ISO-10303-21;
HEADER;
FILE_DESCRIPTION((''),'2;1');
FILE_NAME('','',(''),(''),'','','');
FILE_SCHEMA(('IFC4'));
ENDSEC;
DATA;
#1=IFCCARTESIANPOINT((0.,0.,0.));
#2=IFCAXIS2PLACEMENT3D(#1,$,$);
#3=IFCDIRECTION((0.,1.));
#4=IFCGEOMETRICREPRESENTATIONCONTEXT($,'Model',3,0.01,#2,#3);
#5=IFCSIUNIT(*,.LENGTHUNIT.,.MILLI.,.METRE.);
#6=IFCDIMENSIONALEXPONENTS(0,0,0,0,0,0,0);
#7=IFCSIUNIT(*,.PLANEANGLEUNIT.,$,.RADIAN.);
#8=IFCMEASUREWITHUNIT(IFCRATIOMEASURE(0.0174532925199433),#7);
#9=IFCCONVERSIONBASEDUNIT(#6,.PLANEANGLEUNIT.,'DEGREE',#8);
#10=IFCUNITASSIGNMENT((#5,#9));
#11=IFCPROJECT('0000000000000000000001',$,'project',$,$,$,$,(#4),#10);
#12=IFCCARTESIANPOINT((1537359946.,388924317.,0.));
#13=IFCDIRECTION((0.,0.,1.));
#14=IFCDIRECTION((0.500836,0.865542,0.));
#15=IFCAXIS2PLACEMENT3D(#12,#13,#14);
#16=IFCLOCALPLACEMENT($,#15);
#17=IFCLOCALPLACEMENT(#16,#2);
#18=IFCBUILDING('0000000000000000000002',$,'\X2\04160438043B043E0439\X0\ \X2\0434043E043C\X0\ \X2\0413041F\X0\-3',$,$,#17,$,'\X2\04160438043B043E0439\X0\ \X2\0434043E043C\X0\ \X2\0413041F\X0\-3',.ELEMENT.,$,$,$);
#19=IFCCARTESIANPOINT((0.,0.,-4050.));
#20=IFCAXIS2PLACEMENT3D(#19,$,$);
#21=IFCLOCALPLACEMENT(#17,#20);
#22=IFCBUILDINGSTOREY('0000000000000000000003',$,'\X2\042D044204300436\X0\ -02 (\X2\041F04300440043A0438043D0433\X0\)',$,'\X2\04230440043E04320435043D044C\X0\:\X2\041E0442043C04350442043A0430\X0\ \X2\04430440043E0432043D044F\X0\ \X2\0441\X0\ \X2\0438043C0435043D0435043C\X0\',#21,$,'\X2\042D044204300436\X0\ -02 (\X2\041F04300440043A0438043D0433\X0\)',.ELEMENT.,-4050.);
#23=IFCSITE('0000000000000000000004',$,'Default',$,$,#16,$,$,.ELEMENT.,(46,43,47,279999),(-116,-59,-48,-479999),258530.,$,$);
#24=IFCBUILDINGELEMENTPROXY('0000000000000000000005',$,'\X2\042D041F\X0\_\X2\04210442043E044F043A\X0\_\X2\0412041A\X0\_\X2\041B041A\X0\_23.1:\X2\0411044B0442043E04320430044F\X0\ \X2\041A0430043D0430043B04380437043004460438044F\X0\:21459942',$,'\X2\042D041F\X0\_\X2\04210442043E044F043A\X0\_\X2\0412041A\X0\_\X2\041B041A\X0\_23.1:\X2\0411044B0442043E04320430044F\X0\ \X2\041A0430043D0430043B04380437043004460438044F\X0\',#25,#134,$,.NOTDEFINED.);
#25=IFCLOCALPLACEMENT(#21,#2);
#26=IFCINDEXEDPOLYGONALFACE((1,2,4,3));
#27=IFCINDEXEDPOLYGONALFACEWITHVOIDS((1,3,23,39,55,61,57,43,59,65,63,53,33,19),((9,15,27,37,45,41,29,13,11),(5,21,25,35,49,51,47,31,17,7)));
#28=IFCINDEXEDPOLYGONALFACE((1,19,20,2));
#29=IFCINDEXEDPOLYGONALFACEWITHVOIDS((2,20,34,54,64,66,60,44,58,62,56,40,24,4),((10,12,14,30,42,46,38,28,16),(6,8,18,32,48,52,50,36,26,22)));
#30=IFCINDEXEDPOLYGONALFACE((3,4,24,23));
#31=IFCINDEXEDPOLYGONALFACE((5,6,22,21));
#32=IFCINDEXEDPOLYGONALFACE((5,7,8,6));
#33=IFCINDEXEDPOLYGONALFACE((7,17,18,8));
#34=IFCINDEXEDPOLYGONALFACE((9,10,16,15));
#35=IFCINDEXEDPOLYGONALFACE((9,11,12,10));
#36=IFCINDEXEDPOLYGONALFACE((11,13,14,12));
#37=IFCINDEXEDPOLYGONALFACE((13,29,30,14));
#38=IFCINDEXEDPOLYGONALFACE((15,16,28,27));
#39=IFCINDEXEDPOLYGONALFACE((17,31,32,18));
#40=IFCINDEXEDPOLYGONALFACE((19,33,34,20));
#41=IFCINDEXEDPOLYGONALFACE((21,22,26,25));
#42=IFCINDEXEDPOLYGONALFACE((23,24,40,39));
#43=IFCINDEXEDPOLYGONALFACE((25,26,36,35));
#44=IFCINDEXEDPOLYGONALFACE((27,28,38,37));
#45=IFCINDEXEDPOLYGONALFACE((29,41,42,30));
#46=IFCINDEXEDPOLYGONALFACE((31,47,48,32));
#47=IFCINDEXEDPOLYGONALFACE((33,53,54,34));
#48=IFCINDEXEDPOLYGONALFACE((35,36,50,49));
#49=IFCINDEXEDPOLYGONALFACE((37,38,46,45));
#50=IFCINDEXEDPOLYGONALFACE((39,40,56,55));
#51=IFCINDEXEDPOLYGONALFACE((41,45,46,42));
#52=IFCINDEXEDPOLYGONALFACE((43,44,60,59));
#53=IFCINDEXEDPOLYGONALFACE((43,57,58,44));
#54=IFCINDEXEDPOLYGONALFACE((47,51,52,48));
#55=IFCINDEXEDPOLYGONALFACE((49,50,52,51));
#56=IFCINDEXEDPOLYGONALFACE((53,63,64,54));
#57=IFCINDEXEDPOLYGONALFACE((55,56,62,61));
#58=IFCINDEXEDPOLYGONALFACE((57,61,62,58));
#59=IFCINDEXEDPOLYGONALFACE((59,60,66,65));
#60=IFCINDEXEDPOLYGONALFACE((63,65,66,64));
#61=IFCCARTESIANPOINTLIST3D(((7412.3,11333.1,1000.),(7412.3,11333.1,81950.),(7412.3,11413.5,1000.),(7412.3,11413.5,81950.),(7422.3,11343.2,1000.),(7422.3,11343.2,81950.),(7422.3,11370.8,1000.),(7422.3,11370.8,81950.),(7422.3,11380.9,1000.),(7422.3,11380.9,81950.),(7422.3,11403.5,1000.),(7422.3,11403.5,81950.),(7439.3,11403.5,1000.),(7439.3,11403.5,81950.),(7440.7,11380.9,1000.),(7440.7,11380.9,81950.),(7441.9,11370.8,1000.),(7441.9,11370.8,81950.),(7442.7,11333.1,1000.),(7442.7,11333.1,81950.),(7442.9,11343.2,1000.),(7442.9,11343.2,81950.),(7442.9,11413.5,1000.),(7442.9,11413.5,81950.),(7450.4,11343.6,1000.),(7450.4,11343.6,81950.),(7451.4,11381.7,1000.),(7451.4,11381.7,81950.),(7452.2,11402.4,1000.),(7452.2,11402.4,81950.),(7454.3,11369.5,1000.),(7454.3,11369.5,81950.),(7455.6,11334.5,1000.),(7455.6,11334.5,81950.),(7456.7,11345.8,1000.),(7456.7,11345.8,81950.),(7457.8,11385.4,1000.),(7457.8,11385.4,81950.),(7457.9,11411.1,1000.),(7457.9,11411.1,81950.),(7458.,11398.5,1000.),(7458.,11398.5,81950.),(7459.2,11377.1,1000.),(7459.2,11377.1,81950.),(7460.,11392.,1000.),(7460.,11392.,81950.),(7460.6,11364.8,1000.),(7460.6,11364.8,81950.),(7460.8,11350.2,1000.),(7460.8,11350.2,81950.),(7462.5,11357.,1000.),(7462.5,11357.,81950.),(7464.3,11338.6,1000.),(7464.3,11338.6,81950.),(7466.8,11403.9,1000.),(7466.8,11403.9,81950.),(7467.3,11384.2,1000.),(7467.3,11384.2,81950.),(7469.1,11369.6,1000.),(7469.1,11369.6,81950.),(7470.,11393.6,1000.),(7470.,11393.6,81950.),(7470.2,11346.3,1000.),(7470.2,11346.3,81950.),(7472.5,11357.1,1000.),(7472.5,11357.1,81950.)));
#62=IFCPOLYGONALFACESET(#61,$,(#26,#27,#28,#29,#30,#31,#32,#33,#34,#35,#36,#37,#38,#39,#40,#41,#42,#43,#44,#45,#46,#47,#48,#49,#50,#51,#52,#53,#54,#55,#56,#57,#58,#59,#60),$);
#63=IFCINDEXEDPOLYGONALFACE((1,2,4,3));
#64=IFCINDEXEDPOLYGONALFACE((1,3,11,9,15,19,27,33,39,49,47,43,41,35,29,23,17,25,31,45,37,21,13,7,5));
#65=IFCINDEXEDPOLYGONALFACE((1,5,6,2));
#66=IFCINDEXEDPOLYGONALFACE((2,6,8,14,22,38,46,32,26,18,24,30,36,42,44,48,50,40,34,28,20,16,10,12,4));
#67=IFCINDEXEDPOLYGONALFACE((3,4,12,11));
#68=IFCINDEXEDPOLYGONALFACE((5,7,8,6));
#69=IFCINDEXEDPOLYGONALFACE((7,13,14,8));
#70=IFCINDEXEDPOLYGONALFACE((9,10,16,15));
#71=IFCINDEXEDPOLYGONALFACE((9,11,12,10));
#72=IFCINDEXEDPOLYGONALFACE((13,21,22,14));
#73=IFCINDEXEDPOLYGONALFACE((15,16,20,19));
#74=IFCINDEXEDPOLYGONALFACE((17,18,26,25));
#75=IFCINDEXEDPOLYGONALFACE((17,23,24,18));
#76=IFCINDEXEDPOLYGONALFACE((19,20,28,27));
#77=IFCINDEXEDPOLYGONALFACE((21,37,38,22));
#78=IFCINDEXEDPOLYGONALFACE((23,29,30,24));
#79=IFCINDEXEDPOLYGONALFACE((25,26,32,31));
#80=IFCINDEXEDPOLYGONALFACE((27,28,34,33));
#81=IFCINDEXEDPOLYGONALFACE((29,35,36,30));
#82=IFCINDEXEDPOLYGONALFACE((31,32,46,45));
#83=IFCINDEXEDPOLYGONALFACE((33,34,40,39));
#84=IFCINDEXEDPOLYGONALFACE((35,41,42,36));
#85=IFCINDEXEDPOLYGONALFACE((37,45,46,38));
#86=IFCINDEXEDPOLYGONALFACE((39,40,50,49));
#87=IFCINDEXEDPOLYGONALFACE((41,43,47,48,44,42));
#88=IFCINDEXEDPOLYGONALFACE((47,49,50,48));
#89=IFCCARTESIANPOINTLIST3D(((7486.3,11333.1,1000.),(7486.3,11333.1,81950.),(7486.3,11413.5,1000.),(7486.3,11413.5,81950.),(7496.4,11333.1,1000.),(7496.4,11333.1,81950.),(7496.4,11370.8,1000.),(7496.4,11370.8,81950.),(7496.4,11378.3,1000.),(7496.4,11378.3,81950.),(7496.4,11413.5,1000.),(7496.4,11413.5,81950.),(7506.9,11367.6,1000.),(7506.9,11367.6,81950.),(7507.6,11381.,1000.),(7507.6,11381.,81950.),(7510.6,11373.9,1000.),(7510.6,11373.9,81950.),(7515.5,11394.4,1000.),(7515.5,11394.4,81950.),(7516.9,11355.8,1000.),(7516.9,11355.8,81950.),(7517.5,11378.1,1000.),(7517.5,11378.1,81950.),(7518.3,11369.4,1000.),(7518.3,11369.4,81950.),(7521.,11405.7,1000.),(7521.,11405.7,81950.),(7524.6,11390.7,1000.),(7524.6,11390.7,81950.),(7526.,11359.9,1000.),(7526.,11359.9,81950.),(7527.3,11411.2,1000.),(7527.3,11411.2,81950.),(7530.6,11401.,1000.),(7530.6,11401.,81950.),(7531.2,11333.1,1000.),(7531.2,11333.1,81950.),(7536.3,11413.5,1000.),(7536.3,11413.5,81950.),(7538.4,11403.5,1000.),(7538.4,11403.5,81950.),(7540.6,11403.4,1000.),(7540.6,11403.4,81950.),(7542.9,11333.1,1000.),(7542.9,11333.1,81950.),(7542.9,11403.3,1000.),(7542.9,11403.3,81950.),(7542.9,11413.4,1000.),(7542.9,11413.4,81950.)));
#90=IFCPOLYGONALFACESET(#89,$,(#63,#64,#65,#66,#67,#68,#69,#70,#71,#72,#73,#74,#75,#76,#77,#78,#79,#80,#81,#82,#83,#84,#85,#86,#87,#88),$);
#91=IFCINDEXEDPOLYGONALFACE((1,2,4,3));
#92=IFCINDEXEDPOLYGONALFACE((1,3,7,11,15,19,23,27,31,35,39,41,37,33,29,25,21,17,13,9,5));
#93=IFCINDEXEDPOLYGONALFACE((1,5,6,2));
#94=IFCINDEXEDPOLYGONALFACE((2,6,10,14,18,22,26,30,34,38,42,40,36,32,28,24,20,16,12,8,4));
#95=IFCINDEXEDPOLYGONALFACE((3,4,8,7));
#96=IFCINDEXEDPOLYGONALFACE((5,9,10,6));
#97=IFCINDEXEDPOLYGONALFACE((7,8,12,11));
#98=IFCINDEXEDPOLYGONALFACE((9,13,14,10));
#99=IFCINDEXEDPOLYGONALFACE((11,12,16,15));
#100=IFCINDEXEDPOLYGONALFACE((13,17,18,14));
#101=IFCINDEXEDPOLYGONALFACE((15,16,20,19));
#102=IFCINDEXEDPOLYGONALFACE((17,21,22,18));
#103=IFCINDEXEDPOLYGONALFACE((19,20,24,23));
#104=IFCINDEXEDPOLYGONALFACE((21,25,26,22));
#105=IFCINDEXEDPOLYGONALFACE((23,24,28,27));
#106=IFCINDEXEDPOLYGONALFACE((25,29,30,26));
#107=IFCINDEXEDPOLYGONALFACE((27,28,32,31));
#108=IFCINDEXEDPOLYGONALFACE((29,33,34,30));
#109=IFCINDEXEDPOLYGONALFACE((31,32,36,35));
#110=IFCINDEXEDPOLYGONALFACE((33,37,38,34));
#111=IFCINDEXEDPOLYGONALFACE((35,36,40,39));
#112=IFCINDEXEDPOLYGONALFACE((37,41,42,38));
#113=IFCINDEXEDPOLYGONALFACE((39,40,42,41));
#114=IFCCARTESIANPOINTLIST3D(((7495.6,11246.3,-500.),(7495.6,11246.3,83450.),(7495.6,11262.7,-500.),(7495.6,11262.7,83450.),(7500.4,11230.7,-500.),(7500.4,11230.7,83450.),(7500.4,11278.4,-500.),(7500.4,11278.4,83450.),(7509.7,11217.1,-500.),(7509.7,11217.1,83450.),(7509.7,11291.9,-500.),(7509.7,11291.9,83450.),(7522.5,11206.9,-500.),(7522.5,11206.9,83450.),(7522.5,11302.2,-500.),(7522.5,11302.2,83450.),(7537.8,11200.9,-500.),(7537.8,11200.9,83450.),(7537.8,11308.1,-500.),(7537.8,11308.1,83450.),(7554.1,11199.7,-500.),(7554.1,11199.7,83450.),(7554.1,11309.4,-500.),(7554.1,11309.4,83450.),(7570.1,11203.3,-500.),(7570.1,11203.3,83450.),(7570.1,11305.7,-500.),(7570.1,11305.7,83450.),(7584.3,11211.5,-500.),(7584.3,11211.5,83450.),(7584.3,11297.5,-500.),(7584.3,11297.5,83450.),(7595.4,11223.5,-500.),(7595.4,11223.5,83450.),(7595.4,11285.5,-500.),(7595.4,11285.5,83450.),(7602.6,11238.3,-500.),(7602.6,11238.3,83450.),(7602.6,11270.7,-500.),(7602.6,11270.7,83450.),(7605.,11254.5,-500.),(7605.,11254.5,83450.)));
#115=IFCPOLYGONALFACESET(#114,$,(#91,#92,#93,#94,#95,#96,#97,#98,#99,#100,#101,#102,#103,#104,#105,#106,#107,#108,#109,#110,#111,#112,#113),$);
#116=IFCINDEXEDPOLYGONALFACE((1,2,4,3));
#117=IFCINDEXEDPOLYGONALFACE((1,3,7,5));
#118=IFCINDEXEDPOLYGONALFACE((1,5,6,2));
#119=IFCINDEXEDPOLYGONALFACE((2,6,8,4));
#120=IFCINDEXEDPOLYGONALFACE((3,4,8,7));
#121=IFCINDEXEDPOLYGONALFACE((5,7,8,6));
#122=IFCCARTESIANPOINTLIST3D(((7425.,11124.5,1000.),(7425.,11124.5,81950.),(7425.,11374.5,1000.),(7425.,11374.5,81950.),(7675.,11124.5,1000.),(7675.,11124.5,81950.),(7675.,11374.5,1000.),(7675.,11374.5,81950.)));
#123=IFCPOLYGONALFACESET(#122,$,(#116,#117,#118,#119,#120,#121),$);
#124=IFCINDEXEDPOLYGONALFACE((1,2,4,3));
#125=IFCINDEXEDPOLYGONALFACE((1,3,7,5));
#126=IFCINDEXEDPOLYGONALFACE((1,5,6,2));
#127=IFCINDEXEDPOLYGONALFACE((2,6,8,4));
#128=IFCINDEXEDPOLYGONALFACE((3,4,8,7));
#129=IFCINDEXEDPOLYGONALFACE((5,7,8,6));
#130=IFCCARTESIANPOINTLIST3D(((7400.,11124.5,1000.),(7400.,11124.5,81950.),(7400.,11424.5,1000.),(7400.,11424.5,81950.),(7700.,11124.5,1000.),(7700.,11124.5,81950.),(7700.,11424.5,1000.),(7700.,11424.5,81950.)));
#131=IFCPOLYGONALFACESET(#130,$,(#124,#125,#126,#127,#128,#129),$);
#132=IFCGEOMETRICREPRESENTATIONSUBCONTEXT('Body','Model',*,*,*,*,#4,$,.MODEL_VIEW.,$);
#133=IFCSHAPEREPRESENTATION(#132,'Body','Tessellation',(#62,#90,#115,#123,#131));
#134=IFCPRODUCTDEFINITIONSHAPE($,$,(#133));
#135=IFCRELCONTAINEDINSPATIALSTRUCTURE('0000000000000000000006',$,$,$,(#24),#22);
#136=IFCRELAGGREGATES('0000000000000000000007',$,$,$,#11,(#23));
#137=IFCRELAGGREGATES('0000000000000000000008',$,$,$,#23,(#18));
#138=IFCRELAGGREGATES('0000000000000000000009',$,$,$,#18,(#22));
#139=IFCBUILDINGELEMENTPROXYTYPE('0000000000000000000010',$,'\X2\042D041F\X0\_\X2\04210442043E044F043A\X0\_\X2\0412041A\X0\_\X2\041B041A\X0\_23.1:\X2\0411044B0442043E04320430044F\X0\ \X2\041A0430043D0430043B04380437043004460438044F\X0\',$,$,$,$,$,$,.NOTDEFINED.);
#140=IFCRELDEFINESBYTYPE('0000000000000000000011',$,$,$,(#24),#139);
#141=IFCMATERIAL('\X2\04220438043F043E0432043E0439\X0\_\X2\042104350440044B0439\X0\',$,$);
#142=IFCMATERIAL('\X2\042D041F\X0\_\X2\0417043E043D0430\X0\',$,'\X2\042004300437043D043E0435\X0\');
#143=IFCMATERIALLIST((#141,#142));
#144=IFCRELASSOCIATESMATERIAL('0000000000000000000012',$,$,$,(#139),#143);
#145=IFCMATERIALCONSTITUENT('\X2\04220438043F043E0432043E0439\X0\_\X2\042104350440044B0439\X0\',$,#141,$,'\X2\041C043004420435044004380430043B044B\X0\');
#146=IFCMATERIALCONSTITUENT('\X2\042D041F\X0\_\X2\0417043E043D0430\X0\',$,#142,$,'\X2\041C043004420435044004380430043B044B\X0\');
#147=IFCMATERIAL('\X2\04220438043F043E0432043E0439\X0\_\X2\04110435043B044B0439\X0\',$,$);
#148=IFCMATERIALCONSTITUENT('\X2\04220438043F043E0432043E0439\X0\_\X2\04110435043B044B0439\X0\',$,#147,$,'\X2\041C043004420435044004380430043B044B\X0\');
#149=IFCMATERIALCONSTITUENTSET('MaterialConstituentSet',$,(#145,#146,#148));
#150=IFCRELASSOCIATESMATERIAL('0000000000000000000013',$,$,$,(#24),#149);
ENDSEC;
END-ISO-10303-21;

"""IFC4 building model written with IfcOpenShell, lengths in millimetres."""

from ifc_helpers import new_model, entity, si_unit, converted_unit, direction, frame, frame_2d, origin, place, context, subcontext, project, spatial, polyline, rectangle, circle, outline, extrude, source, transform, mapped, material, material_list, constituent, constituent_set, type_object, type_shapes, element, save


model = new_model("IFC4")

# Units and contexts
model_context = context("Model", 3, precision=0.01, world=origin(), true_north=direction((0.0, 1.0)))
body_context = subcontext(model_context, "Body", "Model", "MODEL_VIEW")
ifc_project = project(units=[si_unit("LENGTHUNIT", "METRE", prefix="MILLI"), converted_unit("PLANEANGLEUNIT", "DEGREE", entity("IfcRatioMeasure", 0.0174532925199433), si_unit("PLANEANGLEUNIT", "RADIAN"), dimensions=[0, 0, 0, 0, 0, 0, 0])], contexts=[model_context])

# Site, building, storey
site_placement = place(None, frame((1537359946.0, 388924317.0, 0.0), z_axis=(0.0, 0.0, 1.0), x_axis=(0.500836, 0.865542, 0.0)))
site = spatial("IfcSite", under=ifc_project, at=site_placement, Name="Default", CompositionType="ELEMENT", RefLatitude=(46, 43, 47, 279999), RefLongitude=(-116, -59, -48, -479999), RefElevation=258530.0)
building_placement = place(site_placement, origin())
building = spatial("IfcBuilding", under=site, at=building_placement, Name="Жилой дом ГП-3", LongName="Жилой дом ГП-3", CompositionType="ELEMENT")
storey_placement = place(building_placement, frame((0.0, 0.0, -4050.0)))
storey = spatial("IfcBuildingStorey", under=building, at=storey_placement, Name="Этаж -02 (Паркинг)", ObjectType="Уровень:Отметка уровня с именем", LongName="Этаж -02 (Паркинг)", CompositionType="ELEMENT", Elevation=-4050.0)

# Building element proxy
ifc_material_1 = material(Name="ЭП_Зона", Category="Разное")
ifc_material_2 = material(Name="Типовой_Белый")
ifc_material_3 = material(Name="Типовой_Серый")
ifc_constituent_1 = constituent(ifc_material_3, Name="Типовой_Серый", Category="Материалы")
ifc_constituent_2 = constituent(ifc_material_1, Name="ЭП_Зона", Category="Материалы")
ifc_constituent_3 = constituent(ifc_material_2, Name="Типовой_Белый", Category="Материалы")
ifc_constituent_set_1 = constituent_set(constituents=[ifc_constituent_1, ifc_constituent_2, ifc_constituent_3], Name="MaterialConstituentSet")
ifc_material_list_1 = material_list([ifc_material_3, ifc_material_1])
building_element_proxy_type_1 = type_object("IfcBuildingElementProxyType", Name="ЭП_Стояк_ВК_ЛК_23.1:Бытовая Канализация", PredefinedType="NOTDEFINED", material=ifc_material_list_1)
shared_shape_1 = source(origin(), body_context, "Body", "SweptSolid", [
    extrude(outline(polyline([(-42.2, -39.0), (-11.8, -39.0), (1.1, -37.6), (9.8, -33.5), (15.7, -25.8), (18.0, -15.0), (14.6, -2.5), (4.7, 5.0), (12.8, 12.1), (15.5, 21.5), (12.3, 31.8), (3.4, 39.0), (-11.6, 41.4), (-42.2, 41.4), (-42.2, -39.0)]), holes=[polyline([(-32.2, 8.8), (-32.2, 31.4), (-15.2, 31.4), (-2.3, 30.3), (3.5, 26.4), (5.5, 19.9), (3.3, 13.3), (-3.1, 9.6), (-13.9, 8.8), (-32.2, 8.8)]), polyline([(-32.2, -28.9), (-32.2, -1.3), (-12.6, -1.3), (-0.2, -2.6), (6.1, -7.3), (8.0, -15.1), (6.3, -21.9), (2.2, -26.3), (-4.1, -28.5), (-11.6, -28.9), (-32.2, -28.9)])]), frame((54.5, -52.4, -3050.0)), (0.0, 0.0, 1.0), 80950.0),
    extrude(outline(polyline([(-32.1, -31.9), (48.3, -31.9), (48.3, -21.8), (10.6, -21.8), (13.8, -11.4), (25.6, -1.3), (48.3, 13.0), (48.3, 24.6), (21.4, 7.7), (12.0, 0.1), (7.4, -7.7), (3.3, -0.7), (-9.3, 6.4), (-19.7, 12.3), (-22.1, 20.2), (-22.0, 22.4), (-22.0, 24.6), (-32.0, 24.6), (-32.1, 18.0), (-29.9, 9.0), (-24.3, 2.8), (-13.1, -2.8), (0.4, -10.6), (3.0, -21.8), (-32.1, -21.8), (-32.1, -31.9)])), frame((118.2, -43.1, -3050.0), z_axis=(0.0, 0.0, 1.0), x_axis=(0.0, -1.0, 0.0)), (0.0, 0.0, 1.0), 80950.0),
    extrude(circle(Radius=55.0, at=frame_2d((0.0, 0.0), x_axis=(1.0, 0.0))), frame((150.0, -170.0, -4550.0)), (0.0, 0.0, 1.0), 83950.0),
    extrude(rectangle(XDim=250.0, YDim=250.0, at=frame_2d((0.0, 0.0), x_axis=(1.0, 0.0))), frame((150.0, -175.0, -3050.0)), (0.0, 0.0, 1.0), 80950.0),
    extrude(rectangle(XDim=300.0, YDim=300.0, at=frame_2d((0.0, 0.0), x_axis=(1.0, 0.0))), frame((150.0, -150.0, -3050.0)), (0.0, 0.0, 1.0), 80950.0),
])
type_shapes(building_element_proxy_type_1, [shared_shape_1])
proxy_1_placement = place(storey_placement, frame((7400.0, 11424.5, 4050.0)))
element("IfcBuildingElementProxy", 1, at=proxy_1_placement, inside=storey, type_object=building_element_proxy_type_1, material=ifc_constituent_set_1, Name="ЭП_Стояк_ВК_ЛК_23.1:Бытовая Канализация:21459942", ObjectType="ЭП_Стояк_ВК_ЛК_23.1:Бытовая Канализация", PredefinedType="NOTDEFINED", context=body_context, shape_type="MappedRepresentation", body=[
    mapped(shared_shape_1, transform((0.0, 0.0, 0.0), scale=1.0)),
])

save(model, "model.ifc")
